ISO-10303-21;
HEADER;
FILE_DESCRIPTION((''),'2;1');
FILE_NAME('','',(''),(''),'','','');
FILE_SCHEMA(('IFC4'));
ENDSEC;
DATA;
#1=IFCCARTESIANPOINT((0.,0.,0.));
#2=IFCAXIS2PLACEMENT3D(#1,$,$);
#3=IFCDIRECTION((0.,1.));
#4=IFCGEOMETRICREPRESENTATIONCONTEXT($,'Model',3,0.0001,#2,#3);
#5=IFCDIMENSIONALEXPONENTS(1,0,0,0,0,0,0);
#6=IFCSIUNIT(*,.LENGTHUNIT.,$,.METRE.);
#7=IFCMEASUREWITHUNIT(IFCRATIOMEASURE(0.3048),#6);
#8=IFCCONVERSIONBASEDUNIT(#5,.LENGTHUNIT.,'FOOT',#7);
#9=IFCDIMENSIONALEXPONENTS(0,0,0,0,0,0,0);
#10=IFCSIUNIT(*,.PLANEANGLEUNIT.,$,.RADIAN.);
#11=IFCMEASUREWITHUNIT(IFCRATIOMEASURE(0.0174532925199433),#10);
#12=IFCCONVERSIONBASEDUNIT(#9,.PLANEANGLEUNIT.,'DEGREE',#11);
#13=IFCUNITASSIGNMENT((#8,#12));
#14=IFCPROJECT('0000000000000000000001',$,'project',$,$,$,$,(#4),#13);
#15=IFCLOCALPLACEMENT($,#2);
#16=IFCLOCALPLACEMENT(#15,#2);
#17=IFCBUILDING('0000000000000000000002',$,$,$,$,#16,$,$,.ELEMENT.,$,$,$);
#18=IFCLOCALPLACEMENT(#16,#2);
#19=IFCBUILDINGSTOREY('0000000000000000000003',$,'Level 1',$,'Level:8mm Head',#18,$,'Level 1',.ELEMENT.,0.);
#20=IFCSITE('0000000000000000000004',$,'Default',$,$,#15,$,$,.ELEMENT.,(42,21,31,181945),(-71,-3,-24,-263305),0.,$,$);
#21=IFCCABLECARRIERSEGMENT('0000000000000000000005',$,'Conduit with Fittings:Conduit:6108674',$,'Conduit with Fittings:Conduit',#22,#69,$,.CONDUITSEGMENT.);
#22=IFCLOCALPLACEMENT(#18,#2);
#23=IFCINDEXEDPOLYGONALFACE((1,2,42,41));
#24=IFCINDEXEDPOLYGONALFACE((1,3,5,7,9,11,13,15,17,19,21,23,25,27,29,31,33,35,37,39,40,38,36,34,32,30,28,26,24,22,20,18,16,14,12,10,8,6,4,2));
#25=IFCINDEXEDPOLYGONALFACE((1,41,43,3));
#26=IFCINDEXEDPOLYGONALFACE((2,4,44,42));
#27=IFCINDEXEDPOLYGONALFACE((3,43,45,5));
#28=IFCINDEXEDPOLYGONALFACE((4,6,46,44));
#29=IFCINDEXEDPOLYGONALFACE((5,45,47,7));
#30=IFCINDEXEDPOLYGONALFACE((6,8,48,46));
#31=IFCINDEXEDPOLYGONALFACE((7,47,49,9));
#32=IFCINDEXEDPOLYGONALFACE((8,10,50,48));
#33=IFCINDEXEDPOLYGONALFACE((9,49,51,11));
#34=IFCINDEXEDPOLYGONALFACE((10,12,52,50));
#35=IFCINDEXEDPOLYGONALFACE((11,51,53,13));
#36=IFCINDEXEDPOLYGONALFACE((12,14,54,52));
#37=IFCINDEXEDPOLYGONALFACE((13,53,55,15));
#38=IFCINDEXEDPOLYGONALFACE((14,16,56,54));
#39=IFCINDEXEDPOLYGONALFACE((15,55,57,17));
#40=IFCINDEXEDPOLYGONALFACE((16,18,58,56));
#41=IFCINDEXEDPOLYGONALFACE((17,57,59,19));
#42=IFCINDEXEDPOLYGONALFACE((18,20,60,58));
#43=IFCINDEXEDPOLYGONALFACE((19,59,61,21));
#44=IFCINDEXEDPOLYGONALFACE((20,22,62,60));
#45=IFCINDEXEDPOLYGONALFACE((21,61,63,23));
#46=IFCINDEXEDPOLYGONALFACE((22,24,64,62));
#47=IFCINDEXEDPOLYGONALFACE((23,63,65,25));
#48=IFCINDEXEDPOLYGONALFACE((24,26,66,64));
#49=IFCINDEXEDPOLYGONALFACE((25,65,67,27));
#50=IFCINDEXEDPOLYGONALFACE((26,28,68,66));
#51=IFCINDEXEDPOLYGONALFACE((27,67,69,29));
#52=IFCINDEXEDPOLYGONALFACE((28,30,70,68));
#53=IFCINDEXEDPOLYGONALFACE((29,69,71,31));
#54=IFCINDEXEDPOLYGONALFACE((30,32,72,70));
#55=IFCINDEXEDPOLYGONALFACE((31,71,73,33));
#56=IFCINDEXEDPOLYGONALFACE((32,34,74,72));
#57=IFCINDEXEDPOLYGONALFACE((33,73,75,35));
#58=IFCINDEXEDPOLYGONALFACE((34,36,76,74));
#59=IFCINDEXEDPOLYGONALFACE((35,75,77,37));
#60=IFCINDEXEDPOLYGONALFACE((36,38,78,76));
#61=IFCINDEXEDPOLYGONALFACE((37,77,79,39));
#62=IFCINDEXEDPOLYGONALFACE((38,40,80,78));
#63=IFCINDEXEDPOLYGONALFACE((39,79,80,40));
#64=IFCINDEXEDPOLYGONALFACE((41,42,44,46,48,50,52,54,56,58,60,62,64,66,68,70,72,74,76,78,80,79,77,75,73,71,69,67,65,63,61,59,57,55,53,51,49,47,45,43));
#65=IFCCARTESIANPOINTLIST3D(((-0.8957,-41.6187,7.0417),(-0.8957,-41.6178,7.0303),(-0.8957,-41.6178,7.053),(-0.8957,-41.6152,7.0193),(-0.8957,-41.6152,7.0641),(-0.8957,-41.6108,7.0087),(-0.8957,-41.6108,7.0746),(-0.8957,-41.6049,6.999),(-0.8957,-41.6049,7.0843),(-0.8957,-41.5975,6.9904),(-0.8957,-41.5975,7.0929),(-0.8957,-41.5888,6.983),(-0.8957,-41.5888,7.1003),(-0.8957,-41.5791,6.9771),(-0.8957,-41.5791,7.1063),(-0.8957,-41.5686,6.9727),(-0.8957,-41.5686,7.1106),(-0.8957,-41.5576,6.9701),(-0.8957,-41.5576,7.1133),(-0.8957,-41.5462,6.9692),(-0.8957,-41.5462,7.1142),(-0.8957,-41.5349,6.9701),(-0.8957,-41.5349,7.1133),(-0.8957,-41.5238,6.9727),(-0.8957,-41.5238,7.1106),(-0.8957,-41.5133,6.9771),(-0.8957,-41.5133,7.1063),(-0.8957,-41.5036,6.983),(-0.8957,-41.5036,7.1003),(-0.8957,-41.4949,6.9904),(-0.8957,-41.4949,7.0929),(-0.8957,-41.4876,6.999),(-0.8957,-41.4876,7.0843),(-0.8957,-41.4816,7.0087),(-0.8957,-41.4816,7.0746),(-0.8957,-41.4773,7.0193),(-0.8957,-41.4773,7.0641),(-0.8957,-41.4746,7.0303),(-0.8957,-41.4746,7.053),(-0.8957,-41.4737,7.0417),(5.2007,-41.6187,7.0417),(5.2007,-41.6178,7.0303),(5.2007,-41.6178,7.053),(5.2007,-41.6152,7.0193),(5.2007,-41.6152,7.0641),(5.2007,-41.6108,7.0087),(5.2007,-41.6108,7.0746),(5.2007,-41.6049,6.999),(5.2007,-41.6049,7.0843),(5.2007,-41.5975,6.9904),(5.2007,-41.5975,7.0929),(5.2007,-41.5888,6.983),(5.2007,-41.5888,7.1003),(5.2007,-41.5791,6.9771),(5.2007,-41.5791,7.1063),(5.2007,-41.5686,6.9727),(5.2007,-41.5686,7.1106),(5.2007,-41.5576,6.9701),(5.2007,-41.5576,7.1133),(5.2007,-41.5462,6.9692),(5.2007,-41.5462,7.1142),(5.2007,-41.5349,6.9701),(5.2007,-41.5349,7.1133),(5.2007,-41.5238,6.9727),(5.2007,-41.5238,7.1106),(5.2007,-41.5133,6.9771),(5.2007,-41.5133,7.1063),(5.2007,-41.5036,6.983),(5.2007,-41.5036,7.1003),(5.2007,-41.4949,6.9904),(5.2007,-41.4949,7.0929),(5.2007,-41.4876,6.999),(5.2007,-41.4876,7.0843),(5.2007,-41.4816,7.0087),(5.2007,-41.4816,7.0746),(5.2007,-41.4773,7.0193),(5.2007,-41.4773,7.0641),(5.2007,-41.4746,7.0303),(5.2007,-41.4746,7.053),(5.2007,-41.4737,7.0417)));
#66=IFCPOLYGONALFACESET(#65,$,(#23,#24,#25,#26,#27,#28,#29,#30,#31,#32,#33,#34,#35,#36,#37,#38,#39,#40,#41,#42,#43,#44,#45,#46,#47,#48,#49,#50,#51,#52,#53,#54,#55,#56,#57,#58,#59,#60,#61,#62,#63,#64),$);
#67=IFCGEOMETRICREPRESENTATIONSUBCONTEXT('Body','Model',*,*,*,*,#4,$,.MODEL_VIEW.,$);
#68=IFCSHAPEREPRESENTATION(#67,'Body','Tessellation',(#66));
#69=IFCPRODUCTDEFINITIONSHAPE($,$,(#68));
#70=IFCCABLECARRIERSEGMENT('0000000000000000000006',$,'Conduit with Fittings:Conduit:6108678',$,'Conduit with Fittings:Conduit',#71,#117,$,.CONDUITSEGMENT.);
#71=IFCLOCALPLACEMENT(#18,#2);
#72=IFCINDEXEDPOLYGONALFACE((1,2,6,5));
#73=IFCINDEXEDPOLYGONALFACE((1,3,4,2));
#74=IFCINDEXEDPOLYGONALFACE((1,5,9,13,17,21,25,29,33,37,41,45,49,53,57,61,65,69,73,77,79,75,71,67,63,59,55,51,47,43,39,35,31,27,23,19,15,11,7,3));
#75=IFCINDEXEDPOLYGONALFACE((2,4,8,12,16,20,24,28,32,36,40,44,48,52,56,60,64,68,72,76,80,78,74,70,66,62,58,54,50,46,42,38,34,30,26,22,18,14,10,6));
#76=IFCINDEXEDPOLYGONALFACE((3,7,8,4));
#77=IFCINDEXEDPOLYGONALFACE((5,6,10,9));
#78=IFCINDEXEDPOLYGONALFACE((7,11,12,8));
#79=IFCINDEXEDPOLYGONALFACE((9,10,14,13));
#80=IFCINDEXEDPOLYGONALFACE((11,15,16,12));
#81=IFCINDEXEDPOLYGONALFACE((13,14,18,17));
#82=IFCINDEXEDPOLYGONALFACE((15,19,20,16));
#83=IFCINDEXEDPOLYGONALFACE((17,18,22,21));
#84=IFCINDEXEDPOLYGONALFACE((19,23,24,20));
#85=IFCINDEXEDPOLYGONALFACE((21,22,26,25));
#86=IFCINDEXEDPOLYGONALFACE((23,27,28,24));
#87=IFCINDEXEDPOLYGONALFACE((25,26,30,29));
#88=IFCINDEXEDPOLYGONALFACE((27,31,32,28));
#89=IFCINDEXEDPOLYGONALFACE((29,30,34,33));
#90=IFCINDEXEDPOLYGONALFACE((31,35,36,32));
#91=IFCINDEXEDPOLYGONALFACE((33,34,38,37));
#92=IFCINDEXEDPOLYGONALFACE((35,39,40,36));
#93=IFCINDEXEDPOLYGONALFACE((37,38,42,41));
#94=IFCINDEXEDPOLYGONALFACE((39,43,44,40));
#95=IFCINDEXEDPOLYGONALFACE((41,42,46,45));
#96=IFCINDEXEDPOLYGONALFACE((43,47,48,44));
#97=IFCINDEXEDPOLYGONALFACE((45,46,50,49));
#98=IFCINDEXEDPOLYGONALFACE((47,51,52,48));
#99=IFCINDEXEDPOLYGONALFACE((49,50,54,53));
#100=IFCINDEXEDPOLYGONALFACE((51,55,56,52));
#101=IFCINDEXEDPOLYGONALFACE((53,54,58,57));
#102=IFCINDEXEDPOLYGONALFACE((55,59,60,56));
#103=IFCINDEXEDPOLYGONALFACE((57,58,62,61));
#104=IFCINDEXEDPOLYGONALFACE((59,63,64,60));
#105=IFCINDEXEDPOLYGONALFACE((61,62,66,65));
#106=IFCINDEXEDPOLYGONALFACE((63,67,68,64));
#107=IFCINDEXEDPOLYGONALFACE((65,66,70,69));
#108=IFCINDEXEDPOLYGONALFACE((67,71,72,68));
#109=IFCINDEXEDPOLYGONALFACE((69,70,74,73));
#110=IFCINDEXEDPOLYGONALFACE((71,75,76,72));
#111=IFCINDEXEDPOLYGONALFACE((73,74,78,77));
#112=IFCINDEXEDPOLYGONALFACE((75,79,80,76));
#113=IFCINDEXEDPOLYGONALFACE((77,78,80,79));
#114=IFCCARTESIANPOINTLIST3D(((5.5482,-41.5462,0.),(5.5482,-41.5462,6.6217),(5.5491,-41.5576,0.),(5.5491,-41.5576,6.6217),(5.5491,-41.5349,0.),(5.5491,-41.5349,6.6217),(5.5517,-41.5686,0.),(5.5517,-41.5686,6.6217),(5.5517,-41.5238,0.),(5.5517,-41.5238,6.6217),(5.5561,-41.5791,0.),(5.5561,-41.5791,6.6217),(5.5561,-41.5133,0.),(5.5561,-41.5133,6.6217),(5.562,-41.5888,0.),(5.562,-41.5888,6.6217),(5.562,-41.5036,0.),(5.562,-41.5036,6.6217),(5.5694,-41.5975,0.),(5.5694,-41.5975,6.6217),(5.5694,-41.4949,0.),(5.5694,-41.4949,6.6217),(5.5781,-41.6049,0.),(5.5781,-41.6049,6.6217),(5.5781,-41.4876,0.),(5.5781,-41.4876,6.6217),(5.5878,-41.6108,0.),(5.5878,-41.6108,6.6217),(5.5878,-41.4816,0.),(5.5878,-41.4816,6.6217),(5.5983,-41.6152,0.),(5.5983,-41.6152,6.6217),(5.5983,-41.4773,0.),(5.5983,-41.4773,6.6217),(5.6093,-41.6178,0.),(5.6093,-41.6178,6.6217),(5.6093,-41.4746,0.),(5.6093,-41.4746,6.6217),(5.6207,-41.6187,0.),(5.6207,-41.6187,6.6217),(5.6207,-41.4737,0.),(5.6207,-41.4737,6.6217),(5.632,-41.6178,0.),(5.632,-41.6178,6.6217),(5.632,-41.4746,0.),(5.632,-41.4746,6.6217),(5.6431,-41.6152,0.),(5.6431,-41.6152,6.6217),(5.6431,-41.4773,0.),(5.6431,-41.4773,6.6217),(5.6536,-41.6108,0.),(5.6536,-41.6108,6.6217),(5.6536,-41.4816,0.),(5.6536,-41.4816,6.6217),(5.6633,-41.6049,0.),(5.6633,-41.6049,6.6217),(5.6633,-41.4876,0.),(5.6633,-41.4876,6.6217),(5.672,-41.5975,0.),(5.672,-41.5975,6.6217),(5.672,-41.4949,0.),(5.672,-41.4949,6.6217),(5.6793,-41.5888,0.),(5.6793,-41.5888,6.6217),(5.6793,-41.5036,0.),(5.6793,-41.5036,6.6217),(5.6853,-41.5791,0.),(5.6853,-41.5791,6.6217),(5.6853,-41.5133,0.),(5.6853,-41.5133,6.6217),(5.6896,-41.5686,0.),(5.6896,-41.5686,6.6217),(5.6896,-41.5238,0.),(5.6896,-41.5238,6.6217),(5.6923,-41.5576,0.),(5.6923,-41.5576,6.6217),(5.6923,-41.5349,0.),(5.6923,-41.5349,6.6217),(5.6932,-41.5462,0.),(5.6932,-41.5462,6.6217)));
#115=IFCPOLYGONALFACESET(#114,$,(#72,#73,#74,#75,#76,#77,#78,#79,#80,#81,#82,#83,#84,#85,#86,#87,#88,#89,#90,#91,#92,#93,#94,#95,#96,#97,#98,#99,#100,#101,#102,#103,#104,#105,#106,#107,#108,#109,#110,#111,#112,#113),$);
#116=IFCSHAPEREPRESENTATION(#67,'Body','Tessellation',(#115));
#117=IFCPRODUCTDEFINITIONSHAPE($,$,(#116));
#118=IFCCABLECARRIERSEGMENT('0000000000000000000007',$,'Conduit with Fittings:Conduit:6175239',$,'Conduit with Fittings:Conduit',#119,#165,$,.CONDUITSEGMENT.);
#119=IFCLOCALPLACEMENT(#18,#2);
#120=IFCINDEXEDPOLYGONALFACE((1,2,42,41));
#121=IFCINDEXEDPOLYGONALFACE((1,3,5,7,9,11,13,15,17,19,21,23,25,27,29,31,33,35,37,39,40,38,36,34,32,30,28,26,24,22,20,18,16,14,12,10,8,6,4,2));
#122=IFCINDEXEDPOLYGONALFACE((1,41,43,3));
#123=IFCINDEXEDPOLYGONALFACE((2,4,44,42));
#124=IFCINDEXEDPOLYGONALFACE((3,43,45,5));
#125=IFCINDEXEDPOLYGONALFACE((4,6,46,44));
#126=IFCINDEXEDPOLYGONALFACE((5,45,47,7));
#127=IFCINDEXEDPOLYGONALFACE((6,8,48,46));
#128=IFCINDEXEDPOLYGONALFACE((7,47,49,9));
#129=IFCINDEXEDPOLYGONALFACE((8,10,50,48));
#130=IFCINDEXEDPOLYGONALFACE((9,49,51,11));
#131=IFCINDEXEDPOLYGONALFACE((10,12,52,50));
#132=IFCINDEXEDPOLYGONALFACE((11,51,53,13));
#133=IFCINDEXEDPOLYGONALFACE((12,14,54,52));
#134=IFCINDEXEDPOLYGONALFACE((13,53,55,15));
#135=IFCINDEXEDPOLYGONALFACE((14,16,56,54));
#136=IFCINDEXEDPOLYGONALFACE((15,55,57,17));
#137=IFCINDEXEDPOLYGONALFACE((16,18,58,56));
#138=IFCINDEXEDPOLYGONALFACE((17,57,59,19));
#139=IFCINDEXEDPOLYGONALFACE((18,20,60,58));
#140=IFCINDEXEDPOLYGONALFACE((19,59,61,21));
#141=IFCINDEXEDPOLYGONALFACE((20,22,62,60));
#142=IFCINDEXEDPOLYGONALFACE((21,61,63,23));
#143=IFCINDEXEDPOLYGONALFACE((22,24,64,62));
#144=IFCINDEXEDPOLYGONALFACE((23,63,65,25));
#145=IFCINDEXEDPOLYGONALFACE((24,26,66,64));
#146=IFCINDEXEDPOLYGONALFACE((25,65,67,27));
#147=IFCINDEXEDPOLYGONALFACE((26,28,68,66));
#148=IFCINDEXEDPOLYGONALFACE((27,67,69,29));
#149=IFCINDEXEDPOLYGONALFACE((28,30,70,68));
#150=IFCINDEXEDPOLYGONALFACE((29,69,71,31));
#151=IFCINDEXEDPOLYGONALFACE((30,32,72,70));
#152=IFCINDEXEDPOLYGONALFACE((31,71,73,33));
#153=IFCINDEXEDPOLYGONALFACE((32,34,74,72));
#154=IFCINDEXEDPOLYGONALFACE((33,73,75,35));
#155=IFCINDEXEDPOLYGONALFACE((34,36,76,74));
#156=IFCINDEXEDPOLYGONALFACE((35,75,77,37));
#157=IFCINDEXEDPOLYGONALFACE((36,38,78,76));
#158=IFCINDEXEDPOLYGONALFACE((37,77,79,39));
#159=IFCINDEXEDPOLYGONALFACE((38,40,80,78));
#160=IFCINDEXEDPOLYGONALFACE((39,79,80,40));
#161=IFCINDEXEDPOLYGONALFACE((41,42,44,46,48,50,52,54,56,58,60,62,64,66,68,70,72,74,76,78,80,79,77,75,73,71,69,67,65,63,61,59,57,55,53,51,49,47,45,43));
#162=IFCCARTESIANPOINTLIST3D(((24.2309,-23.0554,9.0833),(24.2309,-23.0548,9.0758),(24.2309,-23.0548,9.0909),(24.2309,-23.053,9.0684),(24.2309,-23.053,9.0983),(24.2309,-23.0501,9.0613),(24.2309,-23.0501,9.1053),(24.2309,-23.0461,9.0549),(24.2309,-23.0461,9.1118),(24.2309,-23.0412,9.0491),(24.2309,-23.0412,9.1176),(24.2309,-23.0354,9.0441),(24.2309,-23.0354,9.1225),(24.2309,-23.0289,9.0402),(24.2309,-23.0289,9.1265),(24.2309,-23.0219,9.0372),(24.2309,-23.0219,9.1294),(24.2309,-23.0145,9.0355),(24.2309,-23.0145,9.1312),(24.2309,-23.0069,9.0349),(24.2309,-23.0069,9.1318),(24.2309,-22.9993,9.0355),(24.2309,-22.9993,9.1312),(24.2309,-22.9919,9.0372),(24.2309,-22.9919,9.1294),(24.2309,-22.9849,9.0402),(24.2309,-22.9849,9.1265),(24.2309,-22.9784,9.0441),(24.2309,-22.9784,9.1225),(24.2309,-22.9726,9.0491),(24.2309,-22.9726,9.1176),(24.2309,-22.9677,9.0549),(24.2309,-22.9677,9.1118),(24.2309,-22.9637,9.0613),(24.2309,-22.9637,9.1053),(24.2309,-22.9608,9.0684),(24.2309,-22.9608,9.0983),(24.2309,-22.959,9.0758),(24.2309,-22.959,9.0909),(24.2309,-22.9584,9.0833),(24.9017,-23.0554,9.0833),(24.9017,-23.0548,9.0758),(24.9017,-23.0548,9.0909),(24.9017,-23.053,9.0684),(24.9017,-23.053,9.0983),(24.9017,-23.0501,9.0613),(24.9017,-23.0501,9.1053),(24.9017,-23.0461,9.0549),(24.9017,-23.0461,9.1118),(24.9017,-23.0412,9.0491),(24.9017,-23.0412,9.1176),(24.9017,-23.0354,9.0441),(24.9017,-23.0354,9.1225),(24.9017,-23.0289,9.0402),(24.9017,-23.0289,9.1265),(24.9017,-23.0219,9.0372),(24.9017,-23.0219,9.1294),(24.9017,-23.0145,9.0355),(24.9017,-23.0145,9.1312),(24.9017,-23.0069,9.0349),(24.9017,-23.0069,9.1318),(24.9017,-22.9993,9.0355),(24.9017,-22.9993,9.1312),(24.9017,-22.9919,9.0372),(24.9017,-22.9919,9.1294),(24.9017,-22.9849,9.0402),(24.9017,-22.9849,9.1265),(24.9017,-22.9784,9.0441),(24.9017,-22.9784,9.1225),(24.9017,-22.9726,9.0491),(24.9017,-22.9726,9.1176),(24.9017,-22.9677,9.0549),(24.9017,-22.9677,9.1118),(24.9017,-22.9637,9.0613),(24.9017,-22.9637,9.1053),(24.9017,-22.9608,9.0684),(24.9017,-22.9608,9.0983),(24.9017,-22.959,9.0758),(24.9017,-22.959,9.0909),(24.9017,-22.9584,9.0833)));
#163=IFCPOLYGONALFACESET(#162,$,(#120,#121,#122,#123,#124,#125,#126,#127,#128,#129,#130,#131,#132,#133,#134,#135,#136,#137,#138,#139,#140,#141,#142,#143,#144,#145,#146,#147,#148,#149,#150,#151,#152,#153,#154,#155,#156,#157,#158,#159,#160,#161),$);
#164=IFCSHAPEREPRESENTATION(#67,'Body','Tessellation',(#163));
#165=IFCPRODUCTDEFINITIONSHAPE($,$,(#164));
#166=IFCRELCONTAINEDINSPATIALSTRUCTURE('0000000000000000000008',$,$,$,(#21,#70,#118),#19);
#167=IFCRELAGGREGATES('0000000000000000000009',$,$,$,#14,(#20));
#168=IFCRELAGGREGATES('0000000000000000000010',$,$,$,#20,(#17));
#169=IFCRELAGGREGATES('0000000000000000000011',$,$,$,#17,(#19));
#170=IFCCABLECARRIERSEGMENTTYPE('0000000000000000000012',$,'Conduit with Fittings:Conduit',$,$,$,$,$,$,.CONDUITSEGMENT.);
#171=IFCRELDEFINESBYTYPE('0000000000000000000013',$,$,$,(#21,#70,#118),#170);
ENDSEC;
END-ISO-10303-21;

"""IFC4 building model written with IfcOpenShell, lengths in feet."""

from ifc_helpers import new_model, entity, si_unit, converted_unit, direction, frame, origin, place, context, subcontext, project, spatial, indexed_curve, outline, extrude, type_object, element, save


model = new_model("IFC4")

# Units and contexts
model_context = context("Model", 3, precision=0.0001, world=origin(), true_north=direction((0.0, 1.0)))
body_context = subcontext(model_context, "Body", "Model", "MODEL_VIEW")
ifc_project = project(units=[converted_unit("LENGTHUNIT", "FOOT", entity("IfcRatioMeasure", 0.3048), si_unit("LENGTHUNIT", "METRE"), dimensions=[1, 0, 0, 0, 0, 0, 0]), converted_unit("PLANEANGLEUNIT", "DEGREE", entity("IfcRatioMeasure", 0.0174532925199433), si_unit("PLANEANGLEUNIT", "RADIAN"), dimensions=[0, 0, 0, 0, 0, 0, 0])], contexts=[model_context])

# Site, building, storey
site_placement = place(None, origin())
site = spatial("IfcSite", under=ifc_project, at=site_placement, Name="Default", CompositionType="ELEMENT", RefLatitude=(42, 21, 31, 181945), RefLongitude=(-71, -3, -24, -263305), RefElevation=0.0)
building_placement = place(site_placement, origin())
building = spatial("IfcBuilding", under=site, at=building_placement, CompositionType="ELEMENT")
storey_placement = place(building_placement, origin())
storey = spatial("IfcBuildingStorey", under=building, at=storey_placement, Name="Level 1", ObjectType="Level:8mm Head", LongName="Level 1", CompositionType="ELEMENT", Elevation=0.0)

# Cable carrier segments
cable_carrier_segment_type_1 = type_object("IfcCableCarrierSegmentType", Name="Conduit with Fittings:Conduit", PredefinedType="CONDUITSEGMENT")
cable_carrier_segment_1_placement = place(storey_placement, origin())
element("IfcCableCarrierSegment", 1, at=cable_carrier_segment_1_placement, inside=storey, type_object=cable_carrier_segment_type_1, Name="Conduit with Fittings:Conduit:6108674", ObjectType="Conduit with Fittings:Conduit", PredefinedType="CONDUITSEGMENT", context=body_context, shape_type="SweptSolid", body=[
    extrude(outline(indexed_curve([(0.0725, 0.0), (0.0716, 0.0113), (0.069, 0.0224), (0.0646, 0.0329), (0.0587, 0.0426), (0.0513, 0.0513), (0.0426, 0.0587), (0.0329, 0.0646), (0.0224, 0.069), (0.0113, 0.0716), (0.0, 0.0725), (-0.0113, 0.0716), (-0.0224, 0.069), (-0.0329, 0.0646), (-0.0426, 0.0587), (-0.0513, 0.0513), (-0.0587, 0.0426), (-0.0646, 0.0329), (-0.069, 0.0224), (-0.0716, 0.0113), (-0.0725, 0.0), (-0.0716, -0.0113), (-0.069, -0.0224), (-0.0646, -0.0329), (-0.0587, -0.0426), (-0.0513, -0.0513), (-0.0426, -0.0587), (-0.0329, -0.0646), (-0.0224, -0.069), (-0.0113, -0.0716), (0.0, -0.0725), (0.0113, -0.0716), (0.0224, -0.069), (0.0329, -0.0646), (0.0426, -0.0587), (0.0513, -0.0513), (0.0587, -0.0426), (0.0646, -0.0329), (0.069, -0.0224), (0.0716, -0.0113), (0.0725, 0.0)], self_intersect=False)), frame((-0.8957, -41.5462, 7.0417), z_axis=(1.0, 0.0, 0.0), x_axis=(0.0, -1.0, 0.0)), (0.0, 0.0, 1.0), 6.0965),
])
cable_carrier_segment_2_placement = place(storey_placement, origin())
element("IfcCableCarrierSegment", 2, at=cable_carrier_segment_2_placement, inside=storey, type_object=cable_carrier_segment_type_1, Name="Conduit with Fittings:Conduit:6108678", ObjectType="Conduit with Fittings:Conduit", PredefinedType="CONDUITSEGMENT", context=body_context, shape_type="SweptSolid", body=[
    extrude(outline(indexed_curve([(0.0725, 0.0), (0.0716, 0.0113), (0.069, 0.0224), (0.0646, 0.0329), (0.0587, 0.0426), (0.0513, 0.0513), (0.0426, 0.0587), (0.0329, 0.0646), (0.0224, 0.069), (0.0113, 0.0716), (0.0, 0.0725), (-0.0113, 0.0716), (-0.0224, 0.069), (-0.0329, 0.0646), (-0.0426, 0.0587), (-0.0513, 0.0513), (-0.0587, 0.0426), (-0.0646, 0.0329), (-0.069, 0.0224), (-0.0716, 0.0113), (-0.0725, 0.0), (-0.0716, -0.0113), (-0.069, -0.0224), (-0.0646, -0.0329), (-0.0587, -0.0426), (-0.0513, -0.0513), (-0.0426, -0.0587), (-0.0329, -0.0646), (-0.0224, -0.069), (-0.0113, -0.0716), (0.0, -0.0725), (0.0113, -0.0716), (0.0224, -0.069), (0.0329, -0.0646), (0.0426, -0.0587), (0.0513, -0.0513), (0.0587, -0.0426), (0.0646, -0.0329), (0.069, -0.0224), (0.0716, -0.0113), (0.0725, 0.0)], self_intersect=False)), frame((5.6207, -41.5462, 0.0)), (0.0, 0.0, 1.0), 6.6217),
])
cable_carrier_segment_3_placement = place(storey_placement, origin())
element("IfcCableCarrierSegment", 3, at=cable_carrier_segment_3_placement, inside=storey, type_object=cable_carrier_segment_type_1, Name="Conduit with Fittings:Conduit:6175239", ObjectType="Conduit with Fittings:Conduit", PredefinedType="CONDUITSEGMENT", context=body_context, shape_type="SweptSolid", body=[
    extrude(outline(indexed_curve([(0.0485, 0.0), (0.0479, 0.0076), (0.0461, 0.015), (0.0432, 0.022), (0.0392, 0.0285), (0.0343, 0.0343), (0.0285, 0.0392), (0.022, 0.0432), (0.015, 0.0461), (0.0076, 0.0479), (0.0, 0.0485), (-0.0076, 0.0479), (-0.015, 0.0461), (-0.022, 0.0432), (-0.0285, 0.0392), (-0.0343, 0.0343), (-0.0392, 0.0285), (-0.0432, 0.022), (-0.0461, 0.015), (-0.0479, 0.0076), (-0.0485, 0.0), (-0.0479, -0.0076), (-0.0461, -0.015), (-0.0432, -0.022), (-0.0392, -0.0285), (-0.0343, -0.0343), (-0.0285, -0.0392), (-0.022, -0.0432), (-0.015, -0.0461), (-0.0076, -0.0479), (0.0, -0.0485), (0.0076, -0.0479), (0.015, -0.0461), (0.022, -0.0432), (0.0285, -0.0392), (0.0343, -0.0343), (0.0392, -0.0285), (0.0432, -0.022), (0.0461, -0.015), (0.0479, -0.0076), (0.0485, 0.0)], self_intersect=False)), frame((24.2309, -23.0069, 9.0833), z_axis=(1.0, 0.0, 0.0), x_axis=(0.0, -1.0, 0.0)), (0.0, 0.0, 1.0), 0.6708),
])

save(model, "model.ifc")
